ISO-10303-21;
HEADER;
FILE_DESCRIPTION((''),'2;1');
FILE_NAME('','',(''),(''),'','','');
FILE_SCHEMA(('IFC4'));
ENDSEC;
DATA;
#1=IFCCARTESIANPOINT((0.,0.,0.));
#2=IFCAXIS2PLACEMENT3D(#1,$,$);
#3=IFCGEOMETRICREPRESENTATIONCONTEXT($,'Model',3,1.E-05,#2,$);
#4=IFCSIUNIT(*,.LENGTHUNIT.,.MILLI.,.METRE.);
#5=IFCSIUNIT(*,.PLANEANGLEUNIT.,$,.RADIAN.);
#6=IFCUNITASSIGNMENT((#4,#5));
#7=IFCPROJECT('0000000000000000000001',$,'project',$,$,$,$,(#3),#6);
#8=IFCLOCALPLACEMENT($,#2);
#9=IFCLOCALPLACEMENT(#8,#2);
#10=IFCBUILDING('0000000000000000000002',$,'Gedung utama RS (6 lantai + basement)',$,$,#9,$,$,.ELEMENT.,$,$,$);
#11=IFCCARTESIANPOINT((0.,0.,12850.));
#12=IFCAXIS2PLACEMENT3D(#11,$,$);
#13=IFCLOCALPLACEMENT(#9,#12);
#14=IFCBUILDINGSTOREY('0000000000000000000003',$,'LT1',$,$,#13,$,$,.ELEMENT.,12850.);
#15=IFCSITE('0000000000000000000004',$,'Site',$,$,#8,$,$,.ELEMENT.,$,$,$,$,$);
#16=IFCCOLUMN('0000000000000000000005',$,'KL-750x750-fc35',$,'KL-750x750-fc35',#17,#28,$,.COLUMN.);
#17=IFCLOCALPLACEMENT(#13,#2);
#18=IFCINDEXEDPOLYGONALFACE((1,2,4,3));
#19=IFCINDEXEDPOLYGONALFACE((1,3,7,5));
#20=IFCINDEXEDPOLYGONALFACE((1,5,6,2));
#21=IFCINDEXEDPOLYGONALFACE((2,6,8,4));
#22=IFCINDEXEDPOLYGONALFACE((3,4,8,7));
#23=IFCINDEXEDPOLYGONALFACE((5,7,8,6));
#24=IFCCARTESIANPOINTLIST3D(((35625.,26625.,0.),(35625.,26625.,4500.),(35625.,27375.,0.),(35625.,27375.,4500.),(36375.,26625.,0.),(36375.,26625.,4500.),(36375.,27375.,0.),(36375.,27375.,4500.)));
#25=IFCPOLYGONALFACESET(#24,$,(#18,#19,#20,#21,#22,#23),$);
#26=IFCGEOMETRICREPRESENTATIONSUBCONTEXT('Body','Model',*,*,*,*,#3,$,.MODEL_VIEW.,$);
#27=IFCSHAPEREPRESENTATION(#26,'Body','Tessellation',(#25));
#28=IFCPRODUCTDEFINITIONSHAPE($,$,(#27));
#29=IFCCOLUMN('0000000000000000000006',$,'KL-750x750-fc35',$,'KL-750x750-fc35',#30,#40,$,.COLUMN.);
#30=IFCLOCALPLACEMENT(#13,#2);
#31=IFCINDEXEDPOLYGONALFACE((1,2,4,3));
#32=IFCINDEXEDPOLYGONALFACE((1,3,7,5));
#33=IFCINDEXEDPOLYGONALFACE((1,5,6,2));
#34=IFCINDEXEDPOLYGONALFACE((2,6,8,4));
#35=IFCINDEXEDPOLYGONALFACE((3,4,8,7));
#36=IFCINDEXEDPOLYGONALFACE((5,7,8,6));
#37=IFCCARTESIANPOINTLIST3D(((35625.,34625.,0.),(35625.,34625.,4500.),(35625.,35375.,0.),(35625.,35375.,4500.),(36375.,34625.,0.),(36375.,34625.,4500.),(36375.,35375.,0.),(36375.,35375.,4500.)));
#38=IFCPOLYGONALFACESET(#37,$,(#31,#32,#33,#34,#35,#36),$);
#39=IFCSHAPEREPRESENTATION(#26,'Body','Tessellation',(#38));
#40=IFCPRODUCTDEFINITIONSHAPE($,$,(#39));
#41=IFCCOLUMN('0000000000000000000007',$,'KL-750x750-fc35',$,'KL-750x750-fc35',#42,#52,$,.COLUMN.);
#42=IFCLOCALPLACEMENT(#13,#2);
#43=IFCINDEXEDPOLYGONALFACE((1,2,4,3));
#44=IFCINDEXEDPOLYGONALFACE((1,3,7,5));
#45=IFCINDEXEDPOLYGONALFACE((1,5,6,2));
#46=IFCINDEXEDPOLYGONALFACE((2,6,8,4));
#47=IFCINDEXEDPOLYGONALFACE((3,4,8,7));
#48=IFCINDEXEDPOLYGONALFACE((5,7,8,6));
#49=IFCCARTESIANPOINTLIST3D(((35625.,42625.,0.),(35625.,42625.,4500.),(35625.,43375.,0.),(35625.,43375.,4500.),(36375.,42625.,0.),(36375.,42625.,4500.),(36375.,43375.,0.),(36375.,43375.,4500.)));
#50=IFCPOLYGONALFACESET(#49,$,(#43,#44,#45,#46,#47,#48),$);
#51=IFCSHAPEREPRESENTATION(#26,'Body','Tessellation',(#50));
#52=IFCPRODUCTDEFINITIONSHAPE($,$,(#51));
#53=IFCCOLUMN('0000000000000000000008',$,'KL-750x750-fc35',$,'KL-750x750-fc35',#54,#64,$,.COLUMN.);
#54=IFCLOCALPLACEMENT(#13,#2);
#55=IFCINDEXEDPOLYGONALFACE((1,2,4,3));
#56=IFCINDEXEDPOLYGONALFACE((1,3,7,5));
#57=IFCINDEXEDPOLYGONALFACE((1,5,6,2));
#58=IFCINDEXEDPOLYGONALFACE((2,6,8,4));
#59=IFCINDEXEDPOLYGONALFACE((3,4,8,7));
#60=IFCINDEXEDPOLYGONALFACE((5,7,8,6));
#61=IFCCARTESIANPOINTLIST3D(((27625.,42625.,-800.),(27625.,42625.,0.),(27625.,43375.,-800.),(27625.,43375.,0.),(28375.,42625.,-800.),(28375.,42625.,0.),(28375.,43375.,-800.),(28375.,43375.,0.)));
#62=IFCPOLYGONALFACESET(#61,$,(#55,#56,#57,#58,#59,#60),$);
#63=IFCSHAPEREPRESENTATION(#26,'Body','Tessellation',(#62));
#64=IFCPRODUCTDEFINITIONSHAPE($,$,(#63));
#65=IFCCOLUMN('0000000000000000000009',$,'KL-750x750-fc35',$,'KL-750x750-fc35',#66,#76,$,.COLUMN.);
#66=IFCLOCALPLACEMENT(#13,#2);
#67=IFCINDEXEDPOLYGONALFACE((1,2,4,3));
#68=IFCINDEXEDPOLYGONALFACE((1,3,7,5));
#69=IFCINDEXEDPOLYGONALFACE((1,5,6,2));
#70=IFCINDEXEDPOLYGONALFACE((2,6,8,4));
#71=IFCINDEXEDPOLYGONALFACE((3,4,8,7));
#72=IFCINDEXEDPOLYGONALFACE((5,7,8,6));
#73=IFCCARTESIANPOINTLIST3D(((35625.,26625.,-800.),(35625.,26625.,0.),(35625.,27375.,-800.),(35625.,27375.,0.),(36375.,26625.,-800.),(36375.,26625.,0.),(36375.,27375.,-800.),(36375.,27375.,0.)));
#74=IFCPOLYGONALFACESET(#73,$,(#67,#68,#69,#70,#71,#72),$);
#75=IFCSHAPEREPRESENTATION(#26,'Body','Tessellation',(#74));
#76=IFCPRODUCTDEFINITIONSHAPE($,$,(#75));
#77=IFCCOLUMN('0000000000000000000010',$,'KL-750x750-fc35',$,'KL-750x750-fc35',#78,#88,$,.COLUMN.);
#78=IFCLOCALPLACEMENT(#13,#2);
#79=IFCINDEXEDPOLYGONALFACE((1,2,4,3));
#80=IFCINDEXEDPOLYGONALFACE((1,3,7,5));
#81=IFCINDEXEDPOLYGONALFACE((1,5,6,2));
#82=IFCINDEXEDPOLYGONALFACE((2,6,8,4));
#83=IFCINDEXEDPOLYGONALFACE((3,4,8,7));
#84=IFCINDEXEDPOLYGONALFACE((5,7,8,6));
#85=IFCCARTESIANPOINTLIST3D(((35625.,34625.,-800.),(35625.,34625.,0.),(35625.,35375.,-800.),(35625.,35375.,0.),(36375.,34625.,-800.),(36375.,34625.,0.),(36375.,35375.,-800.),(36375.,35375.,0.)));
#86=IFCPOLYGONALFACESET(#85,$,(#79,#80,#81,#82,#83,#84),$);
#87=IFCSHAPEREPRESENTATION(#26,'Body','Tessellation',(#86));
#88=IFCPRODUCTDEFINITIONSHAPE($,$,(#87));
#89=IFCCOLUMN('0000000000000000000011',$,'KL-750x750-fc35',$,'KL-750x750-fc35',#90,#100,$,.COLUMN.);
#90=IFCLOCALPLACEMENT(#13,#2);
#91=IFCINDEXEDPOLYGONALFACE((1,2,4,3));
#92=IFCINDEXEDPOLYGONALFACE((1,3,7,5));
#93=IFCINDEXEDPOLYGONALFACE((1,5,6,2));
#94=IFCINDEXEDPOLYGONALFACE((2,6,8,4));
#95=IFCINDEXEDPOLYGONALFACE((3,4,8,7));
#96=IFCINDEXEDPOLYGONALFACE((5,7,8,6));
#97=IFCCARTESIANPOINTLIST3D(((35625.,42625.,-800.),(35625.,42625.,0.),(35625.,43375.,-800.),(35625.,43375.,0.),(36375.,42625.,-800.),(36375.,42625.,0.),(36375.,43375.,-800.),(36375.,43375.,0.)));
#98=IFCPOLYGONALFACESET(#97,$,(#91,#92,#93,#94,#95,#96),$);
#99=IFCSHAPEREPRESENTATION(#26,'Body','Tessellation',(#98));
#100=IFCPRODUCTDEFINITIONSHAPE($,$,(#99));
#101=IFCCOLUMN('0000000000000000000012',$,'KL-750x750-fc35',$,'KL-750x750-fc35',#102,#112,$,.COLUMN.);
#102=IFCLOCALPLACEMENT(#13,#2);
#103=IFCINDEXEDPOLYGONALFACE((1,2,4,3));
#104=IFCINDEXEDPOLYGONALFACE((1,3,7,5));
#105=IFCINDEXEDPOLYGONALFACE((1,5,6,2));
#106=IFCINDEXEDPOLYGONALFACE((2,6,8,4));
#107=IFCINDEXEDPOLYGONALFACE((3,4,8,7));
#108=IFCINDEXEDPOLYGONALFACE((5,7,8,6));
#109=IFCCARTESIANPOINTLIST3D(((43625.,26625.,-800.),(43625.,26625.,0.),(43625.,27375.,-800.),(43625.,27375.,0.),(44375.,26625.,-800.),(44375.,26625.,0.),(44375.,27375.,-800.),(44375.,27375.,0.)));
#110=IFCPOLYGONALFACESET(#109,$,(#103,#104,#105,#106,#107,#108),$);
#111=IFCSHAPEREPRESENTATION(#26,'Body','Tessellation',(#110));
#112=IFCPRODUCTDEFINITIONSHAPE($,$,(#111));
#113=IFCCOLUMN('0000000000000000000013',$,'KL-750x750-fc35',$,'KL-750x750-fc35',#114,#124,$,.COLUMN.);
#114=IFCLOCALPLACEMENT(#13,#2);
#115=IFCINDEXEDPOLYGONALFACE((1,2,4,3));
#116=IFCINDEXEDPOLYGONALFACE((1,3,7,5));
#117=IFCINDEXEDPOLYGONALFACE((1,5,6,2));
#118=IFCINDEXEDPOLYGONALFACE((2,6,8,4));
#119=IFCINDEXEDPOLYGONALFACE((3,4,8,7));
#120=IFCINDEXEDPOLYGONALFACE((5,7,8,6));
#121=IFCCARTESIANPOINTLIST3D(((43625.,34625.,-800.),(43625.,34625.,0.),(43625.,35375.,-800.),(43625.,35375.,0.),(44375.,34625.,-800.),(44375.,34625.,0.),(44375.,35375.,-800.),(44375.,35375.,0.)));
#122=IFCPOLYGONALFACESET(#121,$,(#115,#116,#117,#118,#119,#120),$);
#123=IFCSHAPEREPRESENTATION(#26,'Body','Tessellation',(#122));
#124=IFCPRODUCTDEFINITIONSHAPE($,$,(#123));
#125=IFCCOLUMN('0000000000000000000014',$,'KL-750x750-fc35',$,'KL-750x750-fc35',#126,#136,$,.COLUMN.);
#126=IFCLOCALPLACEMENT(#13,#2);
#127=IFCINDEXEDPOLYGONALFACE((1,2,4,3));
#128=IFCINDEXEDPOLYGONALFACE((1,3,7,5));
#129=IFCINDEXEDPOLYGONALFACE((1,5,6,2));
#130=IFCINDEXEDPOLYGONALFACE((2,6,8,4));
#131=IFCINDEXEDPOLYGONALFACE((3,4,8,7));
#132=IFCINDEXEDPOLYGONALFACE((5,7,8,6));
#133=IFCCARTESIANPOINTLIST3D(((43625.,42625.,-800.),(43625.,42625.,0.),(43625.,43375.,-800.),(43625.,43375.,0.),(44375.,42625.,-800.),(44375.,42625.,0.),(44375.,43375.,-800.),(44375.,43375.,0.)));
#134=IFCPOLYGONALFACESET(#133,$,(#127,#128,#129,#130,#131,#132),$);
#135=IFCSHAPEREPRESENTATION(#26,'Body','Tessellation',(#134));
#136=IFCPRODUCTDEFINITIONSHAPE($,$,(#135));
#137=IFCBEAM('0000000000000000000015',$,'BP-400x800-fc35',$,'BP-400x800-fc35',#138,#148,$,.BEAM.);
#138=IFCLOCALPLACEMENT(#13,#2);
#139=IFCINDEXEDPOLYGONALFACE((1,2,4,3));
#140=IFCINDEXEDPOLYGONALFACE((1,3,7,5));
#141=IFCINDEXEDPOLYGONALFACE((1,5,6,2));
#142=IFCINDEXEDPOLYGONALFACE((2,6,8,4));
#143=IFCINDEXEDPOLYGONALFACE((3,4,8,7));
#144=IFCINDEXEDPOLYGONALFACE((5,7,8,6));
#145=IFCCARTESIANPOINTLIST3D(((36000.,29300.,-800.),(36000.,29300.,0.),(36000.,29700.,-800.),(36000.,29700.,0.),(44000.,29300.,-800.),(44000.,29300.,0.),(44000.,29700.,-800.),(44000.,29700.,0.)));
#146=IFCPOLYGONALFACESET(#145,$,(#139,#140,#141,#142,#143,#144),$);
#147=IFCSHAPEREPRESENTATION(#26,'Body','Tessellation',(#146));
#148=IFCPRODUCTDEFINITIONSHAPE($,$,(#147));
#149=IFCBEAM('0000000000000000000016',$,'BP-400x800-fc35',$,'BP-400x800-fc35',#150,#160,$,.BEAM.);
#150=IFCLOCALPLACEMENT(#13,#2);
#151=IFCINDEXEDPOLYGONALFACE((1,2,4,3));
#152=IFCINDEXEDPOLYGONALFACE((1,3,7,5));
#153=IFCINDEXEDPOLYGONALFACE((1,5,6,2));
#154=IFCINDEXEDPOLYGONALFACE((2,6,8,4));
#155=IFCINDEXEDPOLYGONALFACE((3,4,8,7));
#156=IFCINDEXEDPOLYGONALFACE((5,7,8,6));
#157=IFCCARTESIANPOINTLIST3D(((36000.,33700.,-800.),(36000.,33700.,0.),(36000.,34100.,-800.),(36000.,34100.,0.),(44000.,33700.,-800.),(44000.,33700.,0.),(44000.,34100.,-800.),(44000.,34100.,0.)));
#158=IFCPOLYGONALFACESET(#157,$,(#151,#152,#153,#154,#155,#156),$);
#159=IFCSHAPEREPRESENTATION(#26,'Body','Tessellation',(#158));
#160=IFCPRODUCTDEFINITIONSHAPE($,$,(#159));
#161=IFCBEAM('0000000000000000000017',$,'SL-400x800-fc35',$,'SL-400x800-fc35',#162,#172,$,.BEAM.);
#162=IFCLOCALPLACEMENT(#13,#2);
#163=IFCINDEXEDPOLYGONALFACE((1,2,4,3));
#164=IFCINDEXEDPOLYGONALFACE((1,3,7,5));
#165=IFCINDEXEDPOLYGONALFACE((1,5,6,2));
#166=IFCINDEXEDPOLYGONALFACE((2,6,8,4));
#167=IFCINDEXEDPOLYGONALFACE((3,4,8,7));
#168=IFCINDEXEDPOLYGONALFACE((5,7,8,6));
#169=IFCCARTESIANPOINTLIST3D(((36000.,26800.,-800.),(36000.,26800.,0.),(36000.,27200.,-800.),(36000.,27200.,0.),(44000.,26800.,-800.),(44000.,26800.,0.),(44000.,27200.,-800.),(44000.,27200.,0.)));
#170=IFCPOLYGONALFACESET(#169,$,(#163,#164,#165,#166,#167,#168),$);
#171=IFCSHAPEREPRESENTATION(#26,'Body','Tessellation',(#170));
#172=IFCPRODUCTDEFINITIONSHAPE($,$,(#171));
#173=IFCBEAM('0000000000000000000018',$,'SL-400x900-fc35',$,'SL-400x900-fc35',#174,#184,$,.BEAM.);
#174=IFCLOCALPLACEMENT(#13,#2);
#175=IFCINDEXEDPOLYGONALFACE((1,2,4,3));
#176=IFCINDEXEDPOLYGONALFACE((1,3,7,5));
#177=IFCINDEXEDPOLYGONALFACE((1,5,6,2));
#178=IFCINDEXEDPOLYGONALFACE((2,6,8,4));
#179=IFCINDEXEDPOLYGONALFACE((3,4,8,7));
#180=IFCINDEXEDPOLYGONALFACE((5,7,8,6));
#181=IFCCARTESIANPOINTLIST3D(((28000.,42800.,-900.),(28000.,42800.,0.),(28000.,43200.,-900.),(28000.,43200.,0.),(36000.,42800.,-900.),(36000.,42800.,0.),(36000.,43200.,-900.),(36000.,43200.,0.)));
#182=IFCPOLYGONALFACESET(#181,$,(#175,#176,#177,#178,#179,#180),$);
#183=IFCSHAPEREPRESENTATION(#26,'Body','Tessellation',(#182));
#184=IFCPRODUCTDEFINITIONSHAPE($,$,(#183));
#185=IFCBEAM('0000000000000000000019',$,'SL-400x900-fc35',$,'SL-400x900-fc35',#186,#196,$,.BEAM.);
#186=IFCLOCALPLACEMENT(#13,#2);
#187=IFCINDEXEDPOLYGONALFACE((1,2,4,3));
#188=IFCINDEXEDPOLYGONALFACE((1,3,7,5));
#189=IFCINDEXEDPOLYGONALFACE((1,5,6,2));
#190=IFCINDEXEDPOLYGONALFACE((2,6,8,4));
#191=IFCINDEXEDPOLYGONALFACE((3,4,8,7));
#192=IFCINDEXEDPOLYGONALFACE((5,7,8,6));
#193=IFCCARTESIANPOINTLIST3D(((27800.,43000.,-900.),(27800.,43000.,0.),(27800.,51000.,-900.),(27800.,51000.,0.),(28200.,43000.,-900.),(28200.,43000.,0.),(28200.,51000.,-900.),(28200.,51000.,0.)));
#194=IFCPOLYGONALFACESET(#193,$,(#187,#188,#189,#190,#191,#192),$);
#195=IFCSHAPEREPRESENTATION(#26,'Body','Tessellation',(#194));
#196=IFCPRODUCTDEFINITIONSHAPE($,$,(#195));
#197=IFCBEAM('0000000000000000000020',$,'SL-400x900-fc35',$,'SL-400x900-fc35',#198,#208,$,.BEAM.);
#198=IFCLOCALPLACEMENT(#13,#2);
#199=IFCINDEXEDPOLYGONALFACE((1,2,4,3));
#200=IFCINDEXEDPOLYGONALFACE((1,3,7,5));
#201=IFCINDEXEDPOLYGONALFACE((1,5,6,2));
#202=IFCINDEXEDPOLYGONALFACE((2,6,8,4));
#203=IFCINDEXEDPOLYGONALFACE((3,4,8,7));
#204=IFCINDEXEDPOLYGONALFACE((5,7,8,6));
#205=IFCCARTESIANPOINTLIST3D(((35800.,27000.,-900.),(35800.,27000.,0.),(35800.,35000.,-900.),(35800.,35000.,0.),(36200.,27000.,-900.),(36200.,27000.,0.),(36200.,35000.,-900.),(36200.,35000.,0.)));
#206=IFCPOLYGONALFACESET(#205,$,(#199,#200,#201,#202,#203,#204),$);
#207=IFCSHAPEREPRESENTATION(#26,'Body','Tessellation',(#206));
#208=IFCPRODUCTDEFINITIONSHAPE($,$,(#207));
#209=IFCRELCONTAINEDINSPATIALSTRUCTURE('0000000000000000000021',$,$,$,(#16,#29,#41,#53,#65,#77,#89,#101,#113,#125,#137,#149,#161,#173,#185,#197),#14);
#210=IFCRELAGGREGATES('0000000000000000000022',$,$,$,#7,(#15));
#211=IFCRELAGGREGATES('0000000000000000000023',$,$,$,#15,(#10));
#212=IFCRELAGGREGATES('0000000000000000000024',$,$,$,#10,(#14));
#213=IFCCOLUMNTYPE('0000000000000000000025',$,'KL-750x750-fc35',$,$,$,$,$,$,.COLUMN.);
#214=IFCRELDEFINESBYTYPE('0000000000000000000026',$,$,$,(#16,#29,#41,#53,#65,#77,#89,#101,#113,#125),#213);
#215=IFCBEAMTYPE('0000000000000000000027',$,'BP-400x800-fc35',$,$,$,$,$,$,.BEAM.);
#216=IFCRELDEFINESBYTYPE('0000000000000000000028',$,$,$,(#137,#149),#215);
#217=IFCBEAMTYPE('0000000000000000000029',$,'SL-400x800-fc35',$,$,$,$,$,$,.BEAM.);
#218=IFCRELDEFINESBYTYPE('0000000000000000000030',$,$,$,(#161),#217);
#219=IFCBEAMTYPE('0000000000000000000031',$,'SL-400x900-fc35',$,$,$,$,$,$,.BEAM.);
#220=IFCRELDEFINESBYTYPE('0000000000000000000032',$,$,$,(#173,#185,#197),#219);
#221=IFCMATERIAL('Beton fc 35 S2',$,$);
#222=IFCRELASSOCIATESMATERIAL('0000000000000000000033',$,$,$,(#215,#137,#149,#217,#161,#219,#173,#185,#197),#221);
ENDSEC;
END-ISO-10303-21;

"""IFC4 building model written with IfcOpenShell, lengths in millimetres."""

from ifc_helpers import new_model, si_unit, frame, origin, origin_2d, place, context, subcontext, project, spatial, rectangle, extrude, material, material_profile, profile_set, profile_usage, type_object, element, save


model = new_model("IFC4")

# Units and contexts
model_context = context("Model", 3, precision=1e-05, world=origin())
body_context = subcontext(model_context, "Body", "Model", "MODEL_VIEW")
ifc_project = project(units=[si_unit("LENGTHUNIT", "METRE", prefix="MILLI"), si_unit("PLANEANGLEUNIT", "RADIAN")], contexts=[model_context])

# Site, building, storey
site_placement = place(None, origin())
site = spatial("IfcSite", under=ifc_project, at=site_placement, Name="Site", CompositionType="ELEMENT")
building_placement = place(site_placement, origin())
building = spatial("IfcBuilding", under=site, at=building_placement, Name="Gedung utama RS (6 lantai + basement)", CompositionType="ELEMENT")
storey_placement = place(building_placement, frame((0.0, 0.0, 12850.0)))
storey = spatial("IfcBuildingStorey", under=building, at=storey_placement, Name="LT1", CompositionType="ELEMENT", Elevation=12850.0)

# Columns
ifc_material_profile_1 = material_profile(None, rectangle(XDim=750.0, YDim=750.0, at=origin_2d()), Name="KL-750x750-fc35")
ifc_profile_set_1 = profile_set([ifc_material_profile_1], Name="KL-750x750-fc35")
ifc_profile_usage_1 = profile_usage(ifc_profile_set_1, cardinal=5)
column_type = type_object("IfcColumnType", Name="KL-750x750-fc35", PredefinedType="COLUMN", material=ifc_profile_set_1)
for number, where, z_axis, x_axis, name in (
    (1, (36000.0, 27000.0, 0.0), (0.0, 0.0, 1.0), (1.0, 0.0, 0.0), "KL-750x750-fc35"),
    (2, (36000.0, 35000.0, 0.0), (0.0, 0.0, 1.0), (1.0, 0.0, 0.0), "KL-750x750-fc35"),
    (3, (36000.0, 43000.0, 0.0), (0.0, 0.0, 1.0), (1.0, 0.0, 0.0), "KL-750x750-fc35"),
):
    element("IfcColumn", number, at=place(storey_placement, frame(where, z_axis=z_axis, x_axis=x_axis)), inside=storey, type_object=column_type, material=ifc_profile_usage_1, Name=name, ObjectType="KL-750x750-fc35", PredefinedType="COLUMN", context=body_context, shape_type="SweptSolid", body=[
        extrude(rectangle(XDim=750.0, YDim=750.0, at=origin_2d()), origin(), (0.0, 0.0, 1.0), 4500.0),
    ])
for number, where, z_axis, x_axis, name in (
    (4, (28000.0, 43000.0, -800.0), (0.0, 0.0, 1.0), (1.0, 0.0, 0.0), "KL-750x750-fc35"),
    (5, (36000.0, 27000.0, -800.0), (0.0, 0.0, 1.0), (1.0, 0.0, 0.0), "KL-750x750-fc35"),
    (6, (36000.0, 35000.0, -800.0), (0.0, 0.0, 1.0), (1.0, 0.0, 0.0), "KL-750x750-fc35"),
    (7, (36000.0, 43000.0, -800.0), (0.0, 0.0, 1.0), (1.0, 0.0, 0.0), "KL-750x750-fc35"),
    (8, (44000.0, 27000.0, -800.0), (0.0, 0.0, 1.0), (1.0, 0.0, 0.0), "KL-750x750-fc35"),
    (9, (44000.0, 35000.0, -800.0), (0.0, 0.0, 1.0), (1.0, 0.0, 0.0), "KL-750x750-fc35"),
    (10, (44000.0, 43000.0, -800.0), (0.0, 0.0, 1.0), (1.0, 0.0, 0.0), "KL-750x750-fc35"),
):
    element("IfcColumn", number, at=place(storey_placement, frame(where, z_axis=z_axis, x_axis=x_axis)), inside=storey, type_object=column_type, material=ifc_profile_usage_1, Name=name, ObjectType="KL-750x750-fc35", PredefinedType="COLUMN", context=body_context, shape_type="SweptSolid", body=[
        extrude(rectangle(XDim=750.0, YDim=750.0, at=origin_2d()), origin(), (0.0, 0.0, 1.0), 800.0),
    ])

# Beams
ifc_material = material(Name="Beton fc 35 S2")
ifc_material_profile_2 = material_profile(ifc_material, rectangle(XDim=400.0, YDim=800.0, at=origin_2d()), Name="BP-400x800-fc35")
ifc_profile_set_2 = profile_set([ifc_material_profile_2], Name="BP-400x800-fc35")
ifc_profile_usage_2 = profile_usage(ifc_profile_set_2, cardinal=8)
beam_type_1 = type_object("IfcBeamType", Name="BP-400x800-fc35", PredefinedType="BEAM", material=ifc_profile_set_2)
for number, where, name in (
    (11, (36000.0, 29500.0, -400.0), "BP-400x800-fc35"),
    (12, (36000.0, 33900.0, -400.0), "BP-400x800-fc35"),
):
    element("IfcBeam", number, at=place(storey_placement, frame(where)), inside=storey, type_object=beam_type_1, material=ifc_profile_usage_2, Name=name, ObjectType="BP-400x800-fc35", PredefinedType="BEAM", context=body_context, shape_type="SweptSolid", body=[
        extrude(rectangle(XDim=400.0, YDim=800.0, at=origin_2d()), frame((0.0, 0.0, 0.0), z_axis=(1.0, 0.0, 0.0), x_axis=(0.0, 1.0, 0.0)), (0.0, 0.0, 1.0), 8000.0),
    ])
ifc_material_profile_3 = material_profile(ifc_material, rectangle(XDim=400.0, YDim=800.0, at=origin_2d()), Name="SL-400x800-fc35")
ifc_profile_set_3 = profile_set([ifc_material_profile_3], Name="SL-400x800-fc35")
ifc_profile_usage_3 = profile_usage(ifc_profile_set_3, cardinal=8)
beam_type_2 = type_object("IfcBeamType", Name="SL-400x800-fc35", PredefinedType="BEAM", material=ifc_profile_set_3)
beam_1_placement = place(storey_placement, frame((36000.0, 27000.0, -400.0)))
element("IfcBeam", 13, at=beam_1_placement, inside=storey, type_object=beam_type_2, material=ifc_profile_usage_3, Name="SL-400x800-fc35", ObjectType="SL-400x800-fc35", PredefinedType="BEAM", context=body_context, shape_type="SweptSolid", body=[
    extrude(rectangle(XDim=400.0, YDim=800.0, at=origin_2d()), frame((0.0, 0.0, 0.0), z_axis=(1.0, 0.0, 0.0), x_axis=(0.0, 1.0, 0.0)), (0.0, 0.0, 1.0), 8000.0),
])
ifc_material_profile_4 = material_profile(ifc_material, rectangle(XDim=400.0, YDim=900.0, at=origin_2d()), Name="SL-400x900-fc35")
ifc_profile_set_4 = profile_set([ifc_material_profile_4], Name="SL-400x900-fc35")
ifc_profile_usage_4 = profile_usage(ifc_profile_set_4, cardinal=8)
beam_type_3 = type_object("IfcBeamType", Name="SL-400x900-fc35", PredefinedType="BEAM", material=ifc_profile_set_4)
beam_2_placement = place(storey_placement, frame((28000.0, 43000.0, -450.0)))
element("IfcBeam", 14, at=beam_2_placement, inside=storey, type_object=beam_type_3, material=ifc_profile_usage_4, Name="SL-400x900-fc35", ObjectType="SL-400x900-fc35", PredefinedType="BEAM", context=body_context, shape_type="SweptSolid", body=[
    extrude(rectangle(XDim=400.0, YDim=900.0, at=origin_2d()), frame((0.0, 0.0, 0.0), z_axis=(1.0, 0.0, 0.0), x_axis=(0.0, 1.0, 0.0)), (0.0, 0.0, 1.0), 8000.0),
])
for number, where, name in (
    (15, (28000.0, 43000.0, -450.0), "SL-400x900-fc35"),
    (16, (36000.0, 27000.0, -450.0), "SL-400x900-fc35"),
):
    element("IfcBeam", number, at=place(storey_placement, frame(where)), inside=storey, type_object=beam_type_3, material=ifc_profile_usage_4, Name=name, ObjectType="SL-400x900-fc35", PredefinedType="BEAM", context=body_context, shape_type="SweptSolid", body=[
        extrude(rectangle(XDim=400.0, YDim=900.0, at=origin_2d()), frame((0.0, 0.0, 0.0), z_axis=(0.0, 1.0, 0.0), x_axis=(-1.0, 0.0, 0.0)), (0.0, 0.0, 1.0), 8000.0),
    ])

save(model, "model.ifc")
